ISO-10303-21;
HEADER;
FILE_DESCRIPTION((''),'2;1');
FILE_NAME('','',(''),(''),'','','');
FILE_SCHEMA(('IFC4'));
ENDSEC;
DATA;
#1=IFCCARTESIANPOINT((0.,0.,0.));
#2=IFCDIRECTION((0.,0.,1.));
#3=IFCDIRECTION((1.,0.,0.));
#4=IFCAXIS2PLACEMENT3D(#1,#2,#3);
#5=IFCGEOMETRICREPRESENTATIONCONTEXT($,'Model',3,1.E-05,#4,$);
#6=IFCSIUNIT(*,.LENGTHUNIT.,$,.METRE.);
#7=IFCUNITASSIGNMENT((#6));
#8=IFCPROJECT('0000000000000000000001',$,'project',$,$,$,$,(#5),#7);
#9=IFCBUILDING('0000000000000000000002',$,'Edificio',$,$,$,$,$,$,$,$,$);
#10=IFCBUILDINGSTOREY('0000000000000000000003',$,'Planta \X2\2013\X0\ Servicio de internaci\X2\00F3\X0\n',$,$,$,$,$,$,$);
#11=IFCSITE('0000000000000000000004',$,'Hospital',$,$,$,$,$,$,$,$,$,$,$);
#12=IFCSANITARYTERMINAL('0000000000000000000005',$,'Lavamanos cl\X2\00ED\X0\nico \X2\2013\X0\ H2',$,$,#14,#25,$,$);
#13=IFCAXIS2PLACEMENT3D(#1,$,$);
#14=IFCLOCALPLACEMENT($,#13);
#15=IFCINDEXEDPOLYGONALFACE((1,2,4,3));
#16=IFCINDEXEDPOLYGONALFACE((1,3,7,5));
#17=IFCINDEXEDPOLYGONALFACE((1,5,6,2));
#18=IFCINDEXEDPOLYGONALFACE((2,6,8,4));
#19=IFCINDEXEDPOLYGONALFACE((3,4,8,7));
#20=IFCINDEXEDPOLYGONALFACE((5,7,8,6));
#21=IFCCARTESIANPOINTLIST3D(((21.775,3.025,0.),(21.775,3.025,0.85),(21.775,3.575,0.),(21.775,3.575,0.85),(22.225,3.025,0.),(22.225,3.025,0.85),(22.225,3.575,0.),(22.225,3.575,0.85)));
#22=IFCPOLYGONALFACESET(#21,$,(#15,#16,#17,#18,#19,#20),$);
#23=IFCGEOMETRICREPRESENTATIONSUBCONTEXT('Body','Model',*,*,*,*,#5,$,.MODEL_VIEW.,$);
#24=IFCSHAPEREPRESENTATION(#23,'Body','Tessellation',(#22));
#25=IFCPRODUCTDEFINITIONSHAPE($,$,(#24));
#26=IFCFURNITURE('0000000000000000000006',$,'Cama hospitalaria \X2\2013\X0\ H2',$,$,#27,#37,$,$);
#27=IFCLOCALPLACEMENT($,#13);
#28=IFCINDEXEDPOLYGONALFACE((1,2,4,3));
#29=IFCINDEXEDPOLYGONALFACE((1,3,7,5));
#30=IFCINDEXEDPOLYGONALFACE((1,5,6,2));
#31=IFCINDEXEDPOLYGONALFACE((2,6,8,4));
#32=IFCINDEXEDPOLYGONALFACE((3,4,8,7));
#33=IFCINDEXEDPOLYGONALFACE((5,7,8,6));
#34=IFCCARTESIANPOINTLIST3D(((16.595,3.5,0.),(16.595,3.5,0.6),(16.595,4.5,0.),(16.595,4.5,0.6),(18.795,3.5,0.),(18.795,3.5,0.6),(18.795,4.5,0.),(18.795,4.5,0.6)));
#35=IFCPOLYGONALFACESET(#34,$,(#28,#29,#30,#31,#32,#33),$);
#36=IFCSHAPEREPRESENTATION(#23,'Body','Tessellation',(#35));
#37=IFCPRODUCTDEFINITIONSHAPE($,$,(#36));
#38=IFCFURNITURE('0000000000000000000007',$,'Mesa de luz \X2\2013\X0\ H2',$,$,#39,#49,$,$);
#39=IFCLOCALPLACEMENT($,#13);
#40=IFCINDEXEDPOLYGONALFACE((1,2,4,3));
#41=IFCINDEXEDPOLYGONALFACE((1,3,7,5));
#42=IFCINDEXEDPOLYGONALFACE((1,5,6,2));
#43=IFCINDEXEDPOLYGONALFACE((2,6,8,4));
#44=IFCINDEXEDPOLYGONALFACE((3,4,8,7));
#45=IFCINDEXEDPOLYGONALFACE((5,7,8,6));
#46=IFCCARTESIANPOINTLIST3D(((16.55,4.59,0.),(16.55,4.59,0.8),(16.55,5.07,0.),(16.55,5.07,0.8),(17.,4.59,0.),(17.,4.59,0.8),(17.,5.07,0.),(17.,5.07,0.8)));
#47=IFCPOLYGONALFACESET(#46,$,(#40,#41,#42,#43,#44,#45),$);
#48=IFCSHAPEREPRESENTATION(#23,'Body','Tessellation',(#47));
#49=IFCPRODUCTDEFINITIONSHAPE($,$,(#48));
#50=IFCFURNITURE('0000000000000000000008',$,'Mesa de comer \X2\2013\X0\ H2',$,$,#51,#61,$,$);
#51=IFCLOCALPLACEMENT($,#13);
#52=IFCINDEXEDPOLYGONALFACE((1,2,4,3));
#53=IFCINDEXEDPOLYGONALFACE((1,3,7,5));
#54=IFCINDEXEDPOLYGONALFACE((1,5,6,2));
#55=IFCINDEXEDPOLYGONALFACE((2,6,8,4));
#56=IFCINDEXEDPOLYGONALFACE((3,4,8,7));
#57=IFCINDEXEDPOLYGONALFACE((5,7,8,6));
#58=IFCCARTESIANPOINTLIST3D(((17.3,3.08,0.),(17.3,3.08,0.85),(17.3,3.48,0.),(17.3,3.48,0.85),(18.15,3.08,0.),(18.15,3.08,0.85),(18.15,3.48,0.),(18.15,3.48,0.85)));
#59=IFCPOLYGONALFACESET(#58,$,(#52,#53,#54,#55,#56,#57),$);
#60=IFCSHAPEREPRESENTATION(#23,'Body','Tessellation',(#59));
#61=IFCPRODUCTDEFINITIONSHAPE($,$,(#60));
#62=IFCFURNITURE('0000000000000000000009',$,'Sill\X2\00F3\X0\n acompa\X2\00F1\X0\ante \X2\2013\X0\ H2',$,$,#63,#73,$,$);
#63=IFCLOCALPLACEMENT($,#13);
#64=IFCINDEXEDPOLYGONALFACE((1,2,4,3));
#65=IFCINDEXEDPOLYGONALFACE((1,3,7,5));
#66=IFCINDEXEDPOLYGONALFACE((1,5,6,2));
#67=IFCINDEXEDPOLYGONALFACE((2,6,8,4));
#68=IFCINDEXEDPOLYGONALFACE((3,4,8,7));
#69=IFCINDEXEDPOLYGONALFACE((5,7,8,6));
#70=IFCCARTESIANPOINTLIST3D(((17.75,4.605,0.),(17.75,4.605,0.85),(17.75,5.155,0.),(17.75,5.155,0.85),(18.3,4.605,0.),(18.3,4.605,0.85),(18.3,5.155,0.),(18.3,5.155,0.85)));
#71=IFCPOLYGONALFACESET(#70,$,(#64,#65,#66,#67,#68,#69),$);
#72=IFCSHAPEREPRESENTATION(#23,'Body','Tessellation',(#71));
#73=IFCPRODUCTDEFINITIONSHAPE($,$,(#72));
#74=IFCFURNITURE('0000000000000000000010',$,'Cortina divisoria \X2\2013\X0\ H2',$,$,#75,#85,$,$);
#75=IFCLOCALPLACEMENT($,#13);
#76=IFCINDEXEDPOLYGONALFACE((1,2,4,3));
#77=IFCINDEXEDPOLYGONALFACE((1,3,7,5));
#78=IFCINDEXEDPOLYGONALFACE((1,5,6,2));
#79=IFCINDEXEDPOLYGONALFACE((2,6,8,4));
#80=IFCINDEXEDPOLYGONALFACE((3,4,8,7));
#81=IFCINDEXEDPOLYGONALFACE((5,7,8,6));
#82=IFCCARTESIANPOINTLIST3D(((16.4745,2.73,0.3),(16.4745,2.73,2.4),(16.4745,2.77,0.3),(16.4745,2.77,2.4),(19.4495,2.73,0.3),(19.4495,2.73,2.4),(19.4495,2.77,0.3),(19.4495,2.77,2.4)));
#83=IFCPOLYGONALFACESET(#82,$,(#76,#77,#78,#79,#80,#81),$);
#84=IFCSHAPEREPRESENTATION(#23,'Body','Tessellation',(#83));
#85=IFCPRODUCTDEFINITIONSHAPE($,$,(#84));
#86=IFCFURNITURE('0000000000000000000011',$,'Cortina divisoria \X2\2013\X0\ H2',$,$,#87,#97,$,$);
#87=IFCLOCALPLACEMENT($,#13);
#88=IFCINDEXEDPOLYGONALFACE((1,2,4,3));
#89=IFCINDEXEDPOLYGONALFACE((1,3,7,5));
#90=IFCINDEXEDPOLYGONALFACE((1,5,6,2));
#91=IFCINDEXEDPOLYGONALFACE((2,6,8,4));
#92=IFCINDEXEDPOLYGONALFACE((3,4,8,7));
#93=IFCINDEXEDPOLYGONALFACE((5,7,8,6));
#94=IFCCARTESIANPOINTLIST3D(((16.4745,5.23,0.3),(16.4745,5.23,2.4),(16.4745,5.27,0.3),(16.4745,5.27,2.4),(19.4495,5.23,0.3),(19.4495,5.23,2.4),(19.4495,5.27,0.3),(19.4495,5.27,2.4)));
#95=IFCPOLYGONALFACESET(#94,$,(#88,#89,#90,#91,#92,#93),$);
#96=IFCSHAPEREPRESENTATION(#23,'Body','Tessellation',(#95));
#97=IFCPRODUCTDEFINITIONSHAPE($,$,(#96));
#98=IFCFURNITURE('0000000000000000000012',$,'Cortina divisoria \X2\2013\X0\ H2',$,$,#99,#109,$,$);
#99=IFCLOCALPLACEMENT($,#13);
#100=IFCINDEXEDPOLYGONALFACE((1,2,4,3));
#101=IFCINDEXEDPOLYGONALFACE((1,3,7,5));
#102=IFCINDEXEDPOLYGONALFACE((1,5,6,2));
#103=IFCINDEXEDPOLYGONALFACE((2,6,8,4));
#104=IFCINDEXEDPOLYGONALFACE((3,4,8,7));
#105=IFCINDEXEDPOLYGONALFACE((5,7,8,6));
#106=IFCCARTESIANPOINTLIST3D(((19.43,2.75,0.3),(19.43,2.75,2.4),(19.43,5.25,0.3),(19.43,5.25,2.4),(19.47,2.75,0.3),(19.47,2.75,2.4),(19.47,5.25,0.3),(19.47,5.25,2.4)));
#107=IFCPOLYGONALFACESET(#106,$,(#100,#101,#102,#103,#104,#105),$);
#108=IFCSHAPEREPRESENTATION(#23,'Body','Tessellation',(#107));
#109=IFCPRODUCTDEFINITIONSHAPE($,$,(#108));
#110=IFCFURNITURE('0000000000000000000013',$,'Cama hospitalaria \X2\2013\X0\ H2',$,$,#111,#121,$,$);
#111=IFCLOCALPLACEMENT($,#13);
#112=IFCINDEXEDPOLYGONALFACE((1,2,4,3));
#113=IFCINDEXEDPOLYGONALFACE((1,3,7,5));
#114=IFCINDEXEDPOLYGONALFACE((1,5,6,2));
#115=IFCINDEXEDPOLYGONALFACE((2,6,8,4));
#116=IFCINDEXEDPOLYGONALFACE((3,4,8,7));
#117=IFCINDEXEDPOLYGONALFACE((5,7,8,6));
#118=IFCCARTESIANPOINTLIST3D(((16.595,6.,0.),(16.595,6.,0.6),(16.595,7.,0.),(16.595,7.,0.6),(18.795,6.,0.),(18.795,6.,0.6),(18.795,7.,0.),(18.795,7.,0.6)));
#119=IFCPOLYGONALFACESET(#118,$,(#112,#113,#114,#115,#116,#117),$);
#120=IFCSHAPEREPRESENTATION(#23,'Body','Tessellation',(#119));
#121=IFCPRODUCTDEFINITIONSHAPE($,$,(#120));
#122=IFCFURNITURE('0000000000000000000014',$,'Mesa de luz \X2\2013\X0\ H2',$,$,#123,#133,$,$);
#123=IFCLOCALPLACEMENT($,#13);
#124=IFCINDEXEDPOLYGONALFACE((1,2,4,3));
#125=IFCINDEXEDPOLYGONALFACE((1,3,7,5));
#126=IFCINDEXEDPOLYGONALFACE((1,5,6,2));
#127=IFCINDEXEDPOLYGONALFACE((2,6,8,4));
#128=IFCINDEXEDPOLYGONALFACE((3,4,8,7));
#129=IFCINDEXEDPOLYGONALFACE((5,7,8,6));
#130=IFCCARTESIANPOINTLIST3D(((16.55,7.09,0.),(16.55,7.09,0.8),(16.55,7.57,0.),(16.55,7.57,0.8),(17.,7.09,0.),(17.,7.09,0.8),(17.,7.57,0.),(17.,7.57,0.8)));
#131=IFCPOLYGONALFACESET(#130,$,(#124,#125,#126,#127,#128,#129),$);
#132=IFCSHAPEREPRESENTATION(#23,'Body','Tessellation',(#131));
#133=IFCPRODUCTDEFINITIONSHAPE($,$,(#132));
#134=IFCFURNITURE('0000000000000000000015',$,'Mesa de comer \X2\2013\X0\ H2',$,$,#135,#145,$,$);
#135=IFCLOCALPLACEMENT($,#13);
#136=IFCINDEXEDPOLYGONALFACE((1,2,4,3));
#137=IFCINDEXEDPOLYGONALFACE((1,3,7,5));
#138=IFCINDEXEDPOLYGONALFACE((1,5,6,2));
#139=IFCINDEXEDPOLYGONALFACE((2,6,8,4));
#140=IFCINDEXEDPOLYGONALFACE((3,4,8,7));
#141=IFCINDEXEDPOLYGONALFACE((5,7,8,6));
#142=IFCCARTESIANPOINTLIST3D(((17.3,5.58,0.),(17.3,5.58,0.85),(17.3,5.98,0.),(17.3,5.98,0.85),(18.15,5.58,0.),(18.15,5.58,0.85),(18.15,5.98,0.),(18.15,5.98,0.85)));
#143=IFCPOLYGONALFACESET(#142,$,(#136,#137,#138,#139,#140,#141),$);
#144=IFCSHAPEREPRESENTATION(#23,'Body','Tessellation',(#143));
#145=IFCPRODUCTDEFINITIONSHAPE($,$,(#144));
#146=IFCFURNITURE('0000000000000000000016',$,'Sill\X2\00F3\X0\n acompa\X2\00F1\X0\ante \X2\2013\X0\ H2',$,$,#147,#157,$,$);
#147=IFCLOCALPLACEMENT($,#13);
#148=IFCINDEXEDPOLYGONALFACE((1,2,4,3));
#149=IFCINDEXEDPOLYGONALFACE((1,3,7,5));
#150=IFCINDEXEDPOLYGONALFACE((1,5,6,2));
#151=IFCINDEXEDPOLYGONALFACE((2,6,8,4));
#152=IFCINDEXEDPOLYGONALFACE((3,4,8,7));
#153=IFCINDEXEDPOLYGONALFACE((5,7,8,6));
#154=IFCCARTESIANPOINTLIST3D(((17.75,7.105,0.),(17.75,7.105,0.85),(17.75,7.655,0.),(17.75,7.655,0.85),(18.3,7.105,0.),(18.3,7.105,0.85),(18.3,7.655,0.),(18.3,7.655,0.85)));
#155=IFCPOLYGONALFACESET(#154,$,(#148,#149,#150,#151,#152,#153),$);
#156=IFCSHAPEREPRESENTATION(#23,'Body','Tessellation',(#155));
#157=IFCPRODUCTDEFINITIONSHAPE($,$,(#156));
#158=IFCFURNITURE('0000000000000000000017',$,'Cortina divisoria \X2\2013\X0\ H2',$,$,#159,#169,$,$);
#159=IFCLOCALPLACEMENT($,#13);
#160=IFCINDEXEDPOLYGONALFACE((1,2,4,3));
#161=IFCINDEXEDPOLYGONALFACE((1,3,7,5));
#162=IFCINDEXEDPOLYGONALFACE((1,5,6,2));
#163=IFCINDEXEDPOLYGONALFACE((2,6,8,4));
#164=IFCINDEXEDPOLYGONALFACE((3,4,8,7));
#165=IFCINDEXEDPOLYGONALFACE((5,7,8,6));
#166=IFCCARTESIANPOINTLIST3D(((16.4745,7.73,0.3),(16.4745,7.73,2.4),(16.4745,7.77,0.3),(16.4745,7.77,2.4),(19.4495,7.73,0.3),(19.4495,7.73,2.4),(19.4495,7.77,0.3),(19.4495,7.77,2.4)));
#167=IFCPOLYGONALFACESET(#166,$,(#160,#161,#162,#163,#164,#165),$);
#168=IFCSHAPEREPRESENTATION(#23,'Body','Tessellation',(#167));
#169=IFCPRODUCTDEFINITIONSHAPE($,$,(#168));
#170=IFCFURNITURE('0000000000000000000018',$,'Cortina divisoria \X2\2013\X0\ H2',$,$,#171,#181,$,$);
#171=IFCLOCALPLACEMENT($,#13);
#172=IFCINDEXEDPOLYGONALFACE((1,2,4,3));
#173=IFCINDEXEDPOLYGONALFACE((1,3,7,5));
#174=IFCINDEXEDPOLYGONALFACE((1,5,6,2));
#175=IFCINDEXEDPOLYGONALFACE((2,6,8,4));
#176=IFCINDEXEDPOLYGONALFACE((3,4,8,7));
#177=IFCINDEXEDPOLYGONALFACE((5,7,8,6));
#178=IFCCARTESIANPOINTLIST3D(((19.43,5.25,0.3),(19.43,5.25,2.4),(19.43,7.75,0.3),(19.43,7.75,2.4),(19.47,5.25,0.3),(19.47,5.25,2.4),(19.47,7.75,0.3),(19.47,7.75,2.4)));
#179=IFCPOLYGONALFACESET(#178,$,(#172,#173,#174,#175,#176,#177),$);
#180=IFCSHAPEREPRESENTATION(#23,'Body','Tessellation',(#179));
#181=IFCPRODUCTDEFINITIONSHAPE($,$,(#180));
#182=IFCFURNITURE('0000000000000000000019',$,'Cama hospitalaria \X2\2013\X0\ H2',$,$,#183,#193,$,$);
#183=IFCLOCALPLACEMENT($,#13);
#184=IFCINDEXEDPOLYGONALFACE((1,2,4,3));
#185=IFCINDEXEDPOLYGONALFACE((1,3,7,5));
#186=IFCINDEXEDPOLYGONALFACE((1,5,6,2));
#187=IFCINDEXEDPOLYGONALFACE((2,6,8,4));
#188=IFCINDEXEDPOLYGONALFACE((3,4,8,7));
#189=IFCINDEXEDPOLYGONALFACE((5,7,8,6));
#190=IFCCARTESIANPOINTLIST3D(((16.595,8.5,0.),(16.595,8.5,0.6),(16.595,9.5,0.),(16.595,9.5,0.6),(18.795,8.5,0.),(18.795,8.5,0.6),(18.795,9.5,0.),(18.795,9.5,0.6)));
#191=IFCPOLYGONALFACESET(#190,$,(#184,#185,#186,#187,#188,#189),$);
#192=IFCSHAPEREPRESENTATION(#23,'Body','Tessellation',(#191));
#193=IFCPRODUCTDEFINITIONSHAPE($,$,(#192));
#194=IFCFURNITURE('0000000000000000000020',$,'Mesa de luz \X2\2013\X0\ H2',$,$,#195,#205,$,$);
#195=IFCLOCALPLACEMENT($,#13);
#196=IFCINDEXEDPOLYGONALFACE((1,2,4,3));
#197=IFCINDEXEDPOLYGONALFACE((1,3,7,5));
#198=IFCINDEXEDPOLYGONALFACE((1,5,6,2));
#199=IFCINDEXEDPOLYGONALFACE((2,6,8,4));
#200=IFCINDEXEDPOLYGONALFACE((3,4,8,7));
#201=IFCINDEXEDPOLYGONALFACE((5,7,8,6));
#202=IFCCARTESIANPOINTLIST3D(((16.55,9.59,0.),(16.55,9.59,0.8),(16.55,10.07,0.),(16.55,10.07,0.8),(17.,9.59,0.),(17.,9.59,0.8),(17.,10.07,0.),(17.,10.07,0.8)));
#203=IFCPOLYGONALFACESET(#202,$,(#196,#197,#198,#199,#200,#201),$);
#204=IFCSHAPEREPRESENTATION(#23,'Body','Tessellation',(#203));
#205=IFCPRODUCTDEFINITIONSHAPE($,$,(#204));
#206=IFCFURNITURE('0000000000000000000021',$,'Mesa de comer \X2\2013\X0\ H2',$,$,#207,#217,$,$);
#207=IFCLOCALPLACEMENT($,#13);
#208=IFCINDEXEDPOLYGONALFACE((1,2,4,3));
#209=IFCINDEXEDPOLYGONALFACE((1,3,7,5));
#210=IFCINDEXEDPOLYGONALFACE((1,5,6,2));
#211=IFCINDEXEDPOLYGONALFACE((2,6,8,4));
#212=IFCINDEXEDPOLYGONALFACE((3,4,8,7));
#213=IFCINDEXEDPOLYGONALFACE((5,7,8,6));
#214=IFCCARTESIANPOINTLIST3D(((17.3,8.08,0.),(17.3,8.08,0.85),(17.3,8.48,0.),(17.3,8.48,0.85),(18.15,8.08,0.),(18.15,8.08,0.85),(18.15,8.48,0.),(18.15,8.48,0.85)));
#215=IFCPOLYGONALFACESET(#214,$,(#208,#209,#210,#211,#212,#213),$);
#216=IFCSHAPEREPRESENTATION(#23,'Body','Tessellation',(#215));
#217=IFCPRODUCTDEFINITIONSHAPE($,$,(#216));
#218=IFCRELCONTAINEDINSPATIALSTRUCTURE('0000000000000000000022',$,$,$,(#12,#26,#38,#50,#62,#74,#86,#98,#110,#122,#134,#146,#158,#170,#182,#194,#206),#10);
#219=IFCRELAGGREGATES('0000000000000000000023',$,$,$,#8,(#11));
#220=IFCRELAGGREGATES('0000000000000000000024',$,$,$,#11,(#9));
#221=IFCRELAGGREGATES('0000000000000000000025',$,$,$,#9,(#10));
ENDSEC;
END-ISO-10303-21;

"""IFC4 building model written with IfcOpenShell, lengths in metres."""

from ifc_helpers import new_model, si_unit, frame, origin_with_axes, context, subcontext, project, spatial, line, indexed_curve, outline, extrude, element, save


model = new_model("IFC4")

# Units and contexts
model_context = context("Model", 3, precision=1e-05, world=origin_with_axes())
body_context = subcontext(model_context, "Body", "Model", "MODEL_VIEW")
ifc_project = project(units=[si_unit("LENGTHUNIT", "METRE")], contexts=[model_context])

# Site, building, storey
site = spatial("IfcSite", under=ifc_project, Name="Hospital")
building = spatial("IfcBuilding", under=site, Name="Edificio")
storey = spatial("IfcBuildingStorey", under=building, Name="Planta – Servicio de internación")

# Sanitary terminal
element("IfcSanitaryTerminal", 1, inside=storey, Name="Lavamanos clínico – H2", context=body_context, shape_type="SweptSolid", body=[
    extrude(outline(indexed_curve([(0.0, 0.0), (0.45, 0.0), (0.45, 0.55), (0.0, 0.55)], segments=[line(1, 2, 3, 4, 1)])), frame((21.775, 3.025, 0.0), z_axis=(0.0, 0.0, 1.0), x_axis=(1.0, 0.0, 0.0)), (0.0, 0.0, 1.0), 0.85),
])

# Furniture
element("IfcFurniture", 2, inside=storey, Name="Cama hospitalaria – H2", context=body_context, shape_type="SweptSolid", body=[
    extrude(outline(indexed_curve([(0.0, 0.0), (2.2, 0.0), (2.2, 1.0), (0.0, 1.0)], segments=[line(1, 2, 3, 4, 1)])), frame((16.595, 3.5, 0.0), z_axis=(0.0, 0.0, 1.0), x_axis=(1.0, 0.0, 0.0)), (0.0, 0.0, 1.0), 0.6),
])
element("IfcFurniture", 3, inside=storey, Name="Mesa de luz – H2", context=body_context, shape_type="SweptSolid", body=[
    extrude(outline(indexed_curve([(0.0, 0.0), (0.45, 0.0), (0.45, 0.48), (0.0, 0.48)], segments=[line(1, 2, 3, 4, 1)])), frame((16.55, 4.59, 0.0), z_axis=(0.0, 0.0, 1.0), x_axis=(1.0, 0.0, 0.0)), (0.0, 0.0, 1.0), 0.8),
])
element("IfcFurniture", 4, inside=storey, Name="Mesa de comer – H2", context=body_context, shape_type="SweptSolid", body=[
    extrude(outline(indexed_curve([(0.0, 0.0), (0.85, 0.0), (0.85, 0.4), (0.0, 0.4)], segments=[line(1, 2, 3, 4, 1)])), frame((17.3, 3.08, 0.0), z_axis=(0.0, 0.0, 1.0), x_axis=(1.0, 0.0, 0.0)), (0.0, 0.0, 1.0), 0.85),
])
element("IfcFurniture", 5, inside=storey, Name="Sillón acompañante – H2", context=body_context, shape_type="SweptSolid", body=[
    extrude(outline(indexed_curve([(0.0, 0.0), (0.55, 0.0), (0.55, 0.55), (0.0, 0.55)], segments=[line(1, 2, 3, 4, 1)])), frame((17.75, 4.605, 0.0), z_axis=(0.0, 0.0, 1.0), x_axis=(1.0, 0.0, 0.0)), (0.0, 0.0, 1.0), 0.85),
])
element("IfcFurniture", 6, inside=storey, Name="Cortina divisoria – H2", context=body_context, shape_type="SweptSolid", body=[
    extrude(outline(indexed_curve([(0.0, 0.0), (2.975, 0.0), (2.975, 0.04), (0.0, 0.04)], segments=[line(1, 2, 3, 4, 1)])), frame((16.4745, 2.73, 0.3), z_axis=(0.0, 0.0, 1.0), x_axis=(1.0, 0.0, 0.0)), (0.0, 0.0, 1.0), 2.1),
])
element("IfcFurniture", 7, inside=storey, Name="Cortina divisoria – H2", context=body_context, shape_type="SweptSolid", body=[
    extrude(outline(indexed_curve([(0.0, 0.0), (2.975, 0.0), (2.975, 0.04), (0.0, 0.04)], segments=[line(1, 2, 3, 4, 1)])), frame((16.4745, 5.23, 0.3), z_axis=(0.0, 0.0, 1.0), x_axis=(1.0, 0.0, 0.0)), (0.0, 0.0, 1.0), 2.1),
])
element("IfcFurniture", 8, inside=storey, Name="Cortina divisoria – H2", context=body_context, shape_type="SweptSolid", body=[
    extrude(outline(indexed_curve([(0.0, 0.0), (0.04, 0.0), (0.04, 2.5), (0.0, 2.5)], segments=[line(1, 2, 3, 4, 1)])), frame((19.43, 2.75, 0.3), z_axis=(0.0, 0.0, 1.0), x_axis=(1.0, 0.0, 0.0)), (0.0, 0.0, 1.0), 2.1),
])
element("IfcFurniture", 9, inside=storey, Name="Cama hospitalaria – H2", context=body_context, shape_type="SweptSolid", body=[
    extrude(outline(indexed_curve([(0.0, 0.0), (2.2, 0.0), (2.2, 1.0), (0.0, 1.0)], segments=[line(1, 2, 3, 4, 1)])), frame((16.595, 6.0, 0.0), z_axis=(0.0, 0.0, 1.0), x_axis=(1.0, 0.0, 0.0)), (0.0, 0.0, 1.0), 0.6),
])
element("IfcFurniture", 10, inside=storey, Name="Mesa de luz – H2", context=body_context, shape_type="SweptSolid", body=[
    extrude(outline(indexed_curve([(0.0, 0.0), (0.45, 0.0), (0.45, 0.48), (0.0, 0.48)], segments=[line(1, 2, 3, 4, 1)])), frame((16.55, 7.09, 0.0), z_axis=(0.0, 0.0, 1.0), x_axis=(1.0, 0.0, 0.0)), (0.0, 0.0, 1.0), 0.8),
])
element("IfcFurniture", 11, inside=storey, Name="Mesa de comer – H2", context=body_context, shape_type="SweptSolid", body=[
    extrude(outline(indexed_curve([(0.0, 0.0), (0.85, 0.0), (0.85, 0.4), (0.0, 0.4)], segments=[line(1, 2, 3, 4, 1)])), frame((17.3, 5.58, 0.0), z_axis=(0.0, 0.0, 1.0), x_axis=(1.0, 0.0, 0.0)), (0.0, 0.0, 1.0), 0.85),
])
element("IfcFurniture", 12, inside=storey, Name="Sillón acompañante – H2", context=body_context, shape_type="SweptSolid", body=[
    extrude(outline(indexed_curve([(0.0, 0.0), (0.55, 0.0), (0.55, 0.55), (0.0, 0.55)], segments=[line(1, 2, 3, 4, 1)])), frame((17.75, 7.105, 0.0), z_axis=(0.0, 0.0, 1.0), x_axis=(1.0, 0.0, 0.0)), (0.0, 0.0, 1.0), 0.85),
])
element("IfcFurniture", 13, inside=storey, Name="Cortina divisoria – H2", context=body_context, shape_type="SweptSolid", body=[
    extrude(outline(indexed_curve([(0.0, 0.0), (2.975, 0.0), (2.975, 0.04), (0.0, 0.04)], segments=[line(1, 2, 3, 4, 1)])), frame((16.4745, 7.73, 0.3), z_axis=(0.0, 0.0, 1.0), x_axis=(1.0, 0.0, 0.0)), (0.0, 0.0, 1.0), 2.1),
])
element("IfcFurniture", 14, inside=storey, Name="Cortina divisoria – H2", context=body_context, shape_type="SweptSolid", body=[
    extrude(outline(indexed_curve([(0.0, 0.0), (0.04, 0.0), (0.04, 2.5), (0.0, 2.5)], segments=[line(1, 2, 3, 4, 1)])), frame((19.43, 5.25, 0.3), z_axis=(0.0, 0.0, 1.0), x_axis=(1.0, 0.0, 0.0)), (0.0, 0.0, 1.0), 2.1),
])
element("IfcFurniture", 15, inside=storey, Name="Cama hospitalaria – H2", context=body_context, shape_type="SweptSolid", body=[
    extrude(outline(indexed_curve([(0.0, 0.0), (2.2, 0.0), (2.2, 1.0), (0.0, 1.0)], segments=[line(1, 2, 3, 4, 1)])), frame((16.595, 8.5, 0.0), z_axis=(0.0, 0.0, 1.0), x_axis=(1.0, 0.0, 0.0)), (0.0, 0.0, 1.0), 0.6),
])
element("IfcFurniture", 16, inside=storey, Name="Mesa de luz – H2", context=body_context, shape_type="SweptSolid", body=[
    extrude(outline(indexed_curve([(0.0, 0.0), (0.45, 0.0), (0.45, 0.48), (0.0, 0.48)], segments=[line(1, 2, 3, 4, 1)])), frame((16.55, 9.59, 0.0), z_axis=(0.0, 0.0, 1.0), x_axis=(1.0, 0.0, 0.0)), (0.0, 0.0, 1.0), 0.8),
])
element("IfcFurniture", 17, inside=storey, Name="Mesa de comer – H2", context=body_context, shape_type="SweptSolid", body=[
    extrude(outline(indexed_curve([(0.0, 0.0), (0.85, 0.0), (0.85, 0.4), (0.0, 0.4)], segments=[line(1, 2, 3, 4, 1)])), frame((17.3, 8.08, 0.0), z_axis=(0.0, 0.0, 1.0), x_axis=(1.0, 0.0, 0.0)), (0.0, 0.0, 1.0), 0.85),
])

save(model, "model.ifc")
